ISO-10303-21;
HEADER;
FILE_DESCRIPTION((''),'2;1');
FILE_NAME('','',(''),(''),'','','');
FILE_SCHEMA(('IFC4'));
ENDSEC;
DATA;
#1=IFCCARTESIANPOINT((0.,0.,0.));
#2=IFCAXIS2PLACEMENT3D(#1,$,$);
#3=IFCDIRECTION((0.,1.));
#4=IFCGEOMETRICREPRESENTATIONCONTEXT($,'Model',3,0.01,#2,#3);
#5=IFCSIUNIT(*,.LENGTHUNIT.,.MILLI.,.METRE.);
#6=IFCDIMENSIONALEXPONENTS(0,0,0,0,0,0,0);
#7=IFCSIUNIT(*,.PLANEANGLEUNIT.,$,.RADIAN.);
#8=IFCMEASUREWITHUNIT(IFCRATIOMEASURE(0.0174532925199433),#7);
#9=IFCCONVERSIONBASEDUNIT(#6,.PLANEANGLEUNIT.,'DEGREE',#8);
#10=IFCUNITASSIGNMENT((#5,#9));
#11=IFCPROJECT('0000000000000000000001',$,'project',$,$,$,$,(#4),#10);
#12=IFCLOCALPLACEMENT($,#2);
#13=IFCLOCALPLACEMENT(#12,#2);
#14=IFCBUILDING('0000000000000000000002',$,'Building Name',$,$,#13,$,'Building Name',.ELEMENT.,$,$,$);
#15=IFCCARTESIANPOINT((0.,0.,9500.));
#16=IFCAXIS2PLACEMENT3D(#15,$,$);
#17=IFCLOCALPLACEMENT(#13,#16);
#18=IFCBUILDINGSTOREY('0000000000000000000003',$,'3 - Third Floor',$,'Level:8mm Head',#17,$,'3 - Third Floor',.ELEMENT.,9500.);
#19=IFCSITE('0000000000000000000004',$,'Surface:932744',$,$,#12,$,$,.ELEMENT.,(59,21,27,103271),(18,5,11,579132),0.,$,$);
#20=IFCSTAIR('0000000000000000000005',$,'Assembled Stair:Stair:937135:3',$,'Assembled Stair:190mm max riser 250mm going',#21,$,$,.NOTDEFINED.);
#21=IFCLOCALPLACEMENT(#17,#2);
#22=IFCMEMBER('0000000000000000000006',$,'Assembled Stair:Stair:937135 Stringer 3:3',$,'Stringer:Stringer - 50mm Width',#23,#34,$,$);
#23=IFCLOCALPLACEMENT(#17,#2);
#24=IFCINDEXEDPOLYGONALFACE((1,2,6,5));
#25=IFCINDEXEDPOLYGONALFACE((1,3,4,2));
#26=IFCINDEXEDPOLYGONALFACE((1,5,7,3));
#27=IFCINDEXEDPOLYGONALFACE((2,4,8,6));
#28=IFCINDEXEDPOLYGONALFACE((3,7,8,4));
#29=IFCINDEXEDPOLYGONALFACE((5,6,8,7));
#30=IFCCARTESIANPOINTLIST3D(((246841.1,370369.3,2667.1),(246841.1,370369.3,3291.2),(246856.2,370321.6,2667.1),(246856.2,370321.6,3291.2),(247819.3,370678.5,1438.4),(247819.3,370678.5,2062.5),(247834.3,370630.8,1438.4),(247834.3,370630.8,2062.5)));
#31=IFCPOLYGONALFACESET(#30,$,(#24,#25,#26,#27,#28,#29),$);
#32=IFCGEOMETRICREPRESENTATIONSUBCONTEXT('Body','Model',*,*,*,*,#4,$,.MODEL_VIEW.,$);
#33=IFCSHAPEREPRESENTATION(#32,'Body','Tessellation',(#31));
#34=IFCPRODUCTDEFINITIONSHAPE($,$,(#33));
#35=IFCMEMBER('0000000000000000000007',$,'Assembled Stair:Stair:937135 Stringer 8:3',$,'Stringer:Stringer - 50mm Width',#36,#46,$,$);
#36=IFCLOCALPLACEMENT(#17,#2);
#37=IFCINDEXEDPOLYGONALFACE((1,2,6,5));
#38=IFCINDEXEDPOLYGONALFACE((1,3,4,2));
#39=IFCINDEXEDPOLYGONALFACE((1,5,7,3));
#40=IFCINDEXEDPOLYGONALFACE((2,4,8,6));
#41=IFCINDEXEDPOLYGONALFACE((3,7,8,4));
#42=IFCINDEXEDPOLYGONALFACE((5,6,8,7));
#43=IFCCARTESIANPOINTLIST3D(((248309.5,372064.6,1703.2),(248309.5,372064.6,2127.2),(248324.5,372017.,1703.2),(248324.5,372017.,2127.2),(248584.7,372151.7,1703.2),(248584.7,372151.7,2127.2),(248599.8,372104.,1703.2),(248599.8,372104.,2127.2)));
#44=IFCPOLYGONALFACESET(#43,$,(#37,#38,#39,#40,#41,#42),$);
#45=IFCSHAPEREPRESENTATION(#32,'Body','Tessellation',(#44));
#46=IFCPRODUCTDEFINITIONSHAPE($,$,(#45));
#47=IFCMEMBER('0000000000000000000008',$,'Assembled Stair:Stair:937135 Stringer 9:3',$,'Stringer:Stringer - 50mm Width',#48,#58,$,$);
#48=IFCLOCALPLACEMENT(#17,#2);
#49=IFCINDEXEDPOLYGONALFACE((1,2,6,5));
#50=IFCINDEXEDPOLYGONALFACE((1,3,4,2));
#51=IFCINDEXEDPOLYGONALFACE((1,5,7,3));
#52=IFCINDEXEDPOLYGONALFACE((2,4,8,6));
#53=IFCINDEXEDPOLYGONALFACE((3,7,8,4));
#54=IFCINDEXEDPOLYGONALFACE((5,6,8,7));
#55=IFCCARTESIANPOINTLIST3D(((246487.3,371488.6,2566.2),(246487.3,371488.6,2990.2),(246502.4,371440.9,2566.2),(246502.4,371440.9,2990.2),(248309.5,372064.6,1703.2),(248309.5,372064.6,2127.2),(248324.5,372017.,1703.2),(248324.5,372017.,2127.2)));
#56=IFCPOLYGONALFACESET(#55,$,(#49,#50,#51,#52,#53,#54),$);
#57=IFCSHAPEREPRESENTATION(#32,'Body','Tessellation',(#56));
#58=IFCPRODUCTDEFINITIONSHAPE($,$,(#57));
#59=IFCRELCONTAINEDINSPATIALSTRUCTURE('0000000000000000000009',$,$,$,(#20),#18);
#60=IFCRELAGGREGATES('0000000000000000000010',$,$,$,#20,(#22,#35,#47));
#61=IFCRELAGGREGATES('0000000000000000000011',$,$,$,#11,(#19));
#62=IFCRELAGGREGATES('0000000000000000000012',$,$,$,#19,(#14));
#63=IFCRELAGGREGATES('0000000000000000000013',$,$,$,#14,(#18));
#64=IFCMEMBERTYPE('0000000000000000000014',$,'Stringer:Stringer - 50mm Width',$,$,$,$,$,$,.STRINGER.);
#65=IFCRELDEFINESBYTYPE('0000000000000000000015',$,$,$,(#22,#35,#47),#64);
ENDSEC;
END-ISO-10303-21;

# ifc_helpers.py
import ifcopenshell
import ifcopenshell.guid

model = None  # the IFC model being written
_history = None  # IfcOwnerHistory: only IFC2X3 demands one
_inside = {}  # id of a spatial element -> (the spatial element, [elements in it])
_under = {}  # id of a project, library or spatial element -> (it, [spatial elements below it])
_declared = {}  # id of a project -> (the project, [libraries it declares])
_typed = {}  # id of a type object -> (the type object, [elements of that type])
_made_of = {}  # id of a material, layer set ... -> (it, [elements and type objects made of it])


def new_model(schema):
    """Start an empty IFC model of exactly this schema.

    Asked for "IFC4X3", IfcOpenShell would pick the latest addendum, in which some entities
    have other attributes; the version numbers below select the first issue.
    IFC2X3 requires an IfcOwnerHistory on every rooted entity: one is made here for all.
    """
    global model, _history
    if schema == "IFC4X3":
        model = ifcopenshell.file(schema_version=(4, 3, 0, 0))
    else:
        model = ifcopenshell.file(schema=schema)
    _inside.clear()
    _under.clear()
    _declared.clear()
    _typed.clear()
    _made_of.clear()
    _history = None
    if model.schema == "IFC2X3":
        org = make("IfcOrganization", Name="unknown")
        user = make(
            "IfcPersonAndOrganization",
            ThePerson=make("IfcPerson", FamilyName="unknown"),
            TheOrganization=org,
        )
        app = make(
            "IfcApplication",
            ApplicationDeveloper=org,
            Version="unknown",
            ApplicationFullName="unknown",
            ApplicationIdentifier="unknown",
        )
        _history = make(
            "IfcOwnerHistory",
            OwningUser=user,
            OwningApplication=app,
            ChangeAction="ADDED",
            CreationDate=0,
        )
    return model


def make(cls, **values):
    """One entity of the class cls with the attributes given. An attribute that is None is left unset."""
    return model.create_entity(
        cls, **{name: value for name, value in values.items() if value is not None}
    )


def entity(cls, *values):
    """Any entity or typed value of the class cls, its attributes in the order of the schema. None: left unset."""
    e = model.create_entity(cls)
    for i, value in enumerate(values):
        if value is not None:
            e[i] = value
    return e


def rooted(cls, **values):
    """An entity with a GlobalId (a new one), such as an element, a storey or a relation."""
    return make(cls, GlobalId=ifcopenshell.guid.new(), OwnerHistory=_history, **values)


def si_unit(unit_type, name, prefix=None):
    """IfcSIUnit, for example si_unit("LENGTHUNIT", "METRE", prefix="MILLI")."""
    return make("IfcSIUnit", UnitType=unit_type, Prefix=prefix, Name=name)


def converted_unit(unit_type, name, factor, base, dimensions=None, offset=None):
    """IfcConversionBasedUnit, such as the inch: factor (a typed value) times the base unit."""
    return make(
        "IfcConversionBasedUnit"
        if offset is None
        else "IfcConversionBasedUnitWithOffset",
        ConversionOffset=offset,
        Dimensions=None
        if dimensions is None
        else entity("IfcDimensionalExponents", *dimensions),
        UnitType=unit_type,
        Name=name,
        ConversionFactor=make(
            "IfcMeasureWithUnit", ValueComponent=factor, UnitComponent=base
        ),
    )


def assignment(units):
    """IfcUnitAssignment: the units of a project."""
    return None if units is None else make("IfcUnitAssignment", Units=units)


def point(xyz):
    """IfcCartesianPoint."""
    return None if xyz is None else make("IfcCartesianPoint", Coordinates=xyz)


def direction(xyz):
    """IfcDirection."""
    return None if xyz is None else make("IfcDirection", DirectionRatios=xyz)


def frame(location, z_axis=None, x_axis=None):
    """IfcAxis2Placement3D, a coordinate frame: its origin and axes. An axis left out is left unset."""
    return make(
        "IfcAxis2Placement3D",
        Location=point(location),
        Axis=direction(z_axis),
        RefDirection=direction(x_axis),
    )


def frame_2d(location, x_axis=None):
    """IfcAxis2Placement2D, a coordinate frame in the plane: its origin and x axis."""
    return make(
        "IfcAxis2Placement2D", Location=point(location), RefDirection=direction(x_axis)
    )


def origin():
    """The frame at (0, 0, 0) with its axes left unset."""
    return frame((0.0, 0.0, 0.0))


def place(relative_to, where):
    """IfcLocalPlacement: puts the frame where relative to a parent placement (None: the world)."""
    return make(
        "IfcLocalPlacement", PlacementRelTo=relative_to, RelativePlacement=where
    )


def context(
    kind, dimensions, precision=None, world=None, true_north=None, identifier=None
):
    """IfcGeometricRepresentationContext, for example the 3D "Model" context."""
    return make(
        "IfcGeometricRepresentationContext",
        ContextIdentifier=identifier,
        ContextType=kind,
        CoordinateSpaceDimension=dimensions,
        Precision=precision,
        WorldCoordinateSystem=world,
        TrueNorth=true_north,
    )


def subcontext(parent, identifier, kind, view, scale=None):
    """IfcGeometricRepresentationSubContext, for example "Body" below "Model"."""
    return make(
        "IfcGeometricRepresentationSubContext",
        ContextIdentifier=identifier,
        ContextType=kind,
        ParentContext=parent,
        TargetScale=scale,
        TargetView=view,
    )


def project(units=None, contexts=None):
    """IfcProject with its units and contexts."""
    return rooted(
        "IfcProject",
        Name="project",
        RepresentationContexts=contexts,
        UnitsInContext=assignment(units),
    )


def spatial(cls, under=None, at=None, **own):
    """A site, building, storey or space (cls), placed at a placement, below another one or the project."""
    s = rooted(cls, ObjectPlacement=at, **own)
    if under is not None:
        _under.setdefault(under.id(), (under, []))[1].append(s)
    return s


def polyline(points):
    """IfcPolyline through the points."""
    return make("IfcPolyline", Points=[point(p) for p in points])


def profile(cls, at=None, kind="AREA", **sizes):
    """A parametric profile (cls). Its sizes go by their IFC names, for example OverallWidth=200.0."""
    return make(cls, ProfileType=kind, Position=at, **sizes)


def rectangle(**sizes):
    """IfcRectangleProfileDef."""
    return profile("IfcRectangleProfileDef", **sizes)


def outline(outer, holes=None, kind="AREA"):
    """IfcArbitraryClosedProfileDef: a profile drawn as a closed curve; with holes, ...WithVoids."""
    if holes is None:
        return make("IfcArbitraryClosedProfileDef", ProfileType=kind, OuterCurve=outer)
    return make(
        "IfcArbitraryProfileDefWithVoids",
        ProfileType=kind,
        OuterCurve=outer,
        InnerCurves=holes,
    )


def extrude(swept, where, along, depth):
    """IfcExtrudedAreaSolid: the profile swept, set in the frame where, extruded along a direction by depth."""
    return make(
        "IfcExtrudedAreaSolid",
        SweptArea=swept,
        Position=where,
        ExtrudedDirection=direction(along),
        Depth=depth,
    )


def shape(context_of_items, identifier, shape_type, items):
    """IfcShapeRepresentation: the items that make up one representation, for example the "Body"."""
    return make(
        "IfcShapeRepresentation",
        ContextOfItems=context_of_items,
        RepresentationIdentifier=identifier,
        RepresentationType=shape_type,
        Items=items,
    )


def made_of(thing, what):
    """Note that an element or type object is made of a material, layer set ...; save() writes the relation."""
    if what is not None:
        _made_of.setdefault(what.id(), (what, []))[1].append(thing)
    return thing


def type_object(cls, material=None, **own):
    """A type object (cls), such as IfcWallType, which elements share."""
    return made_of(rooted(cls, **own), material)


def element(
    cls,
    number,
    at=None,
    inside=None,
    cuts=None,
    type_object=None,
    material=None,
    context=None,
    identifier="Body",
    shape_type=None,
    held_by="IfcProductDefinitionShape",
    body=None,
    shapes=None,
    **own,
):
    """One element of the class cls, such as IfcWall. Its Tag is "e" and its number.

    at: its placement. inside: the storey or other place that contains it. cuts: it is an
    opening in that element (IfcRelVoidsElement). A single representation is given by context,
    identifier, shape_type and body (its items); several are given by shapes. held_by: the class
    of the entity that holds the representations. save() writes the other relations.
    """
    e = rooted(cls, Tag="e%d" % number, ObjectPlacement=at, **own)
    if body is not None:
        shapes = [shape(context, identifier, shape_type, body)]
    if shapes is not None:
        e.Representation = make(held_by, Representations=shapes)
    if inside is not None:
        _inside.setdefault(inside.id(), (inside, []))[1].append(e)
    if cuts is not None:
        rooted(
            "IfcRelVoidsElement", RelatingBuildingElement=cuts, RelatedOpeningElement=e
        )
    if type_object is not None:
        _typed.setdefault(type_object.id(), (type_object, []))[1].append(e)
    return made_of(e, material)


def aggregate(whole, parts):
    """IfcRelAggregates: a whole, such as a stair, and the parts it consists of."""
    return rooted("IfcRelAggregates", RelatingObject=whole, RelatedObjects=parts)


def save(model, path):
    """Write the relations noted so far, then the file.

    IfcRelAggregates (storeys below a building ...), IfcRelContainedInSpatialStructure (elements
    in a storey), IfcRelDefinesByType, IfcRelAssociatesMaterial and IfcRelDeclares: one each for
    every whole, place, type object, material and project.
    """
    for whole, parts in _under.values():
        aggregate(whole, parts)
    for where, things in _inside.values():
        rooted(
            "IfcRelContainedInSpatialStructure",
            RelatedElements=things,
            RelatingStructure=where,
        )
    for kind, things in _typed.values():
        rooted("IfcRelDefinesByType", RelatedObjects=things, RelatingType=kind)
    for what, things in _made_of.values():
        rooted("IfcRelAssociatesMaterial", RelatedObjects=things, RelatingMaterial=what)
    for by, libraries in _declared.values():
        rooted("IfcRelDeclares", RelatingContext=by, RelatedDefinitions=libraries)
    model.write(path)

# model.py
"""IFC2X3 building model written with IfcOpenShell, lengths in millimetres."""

from ifc_helpers import new_model, entity, si_unit, converted_unit, direction, frame, frame_2d, origin, place, context, subcontext, project, spatial, polyline, rectangle, outline, extrude, type_object, element, aggregate, save


model = new_model("IFC2X3")

# Units and contexts
model_context = context("Model", 3, precision=0.01, world=origin(), true_north=direction((0.0, 1.0)))
body_context = subcontext(model_context, "Body", "Model", "MODEL_VIEW")
ifc_project = project(units=[si_unit("LENGTHUNIT", "METRE", prefix="MILLI"), converted_unit("PLANEANGLEUNIT", "DEGREE", entity("IfcRatioMeasure", 0.0174532925199433), si_unit("PLANEANGLEUNIT", "RADIAN"), dimensions=[0, 0, 0, 0, 0, 0, 0])], contexts=[model_context])

# Site, building, storey
site_placement = place(None, origin())
site = spatial("IfcSite", under=ifc_project, at=site_placement, Name="Surface:932744", CompositionType="ELEMENT", RefLatitude=(59, 21, 27, 103271), RefLongitude=(18, 5, 11, 579132), RefElevation=0.0)
building_placement = place(site_placement, origin())
building = spatial("IfcBuilding", under=site, at=building_placement, Name="Building Name", LongName="Building Name", CompositionType="ELEMENT")
storey_placement = place(building_placement, frame((0.0, 0.0, 9500.0)))
storey = spatial("IfcBuildingStorey", under=building, at=storey_placement, Name="3 - Third Floor", ObjectType="Level:8mm Head", LongName="3 - Third Floor", CompositionType="ELEMENT", Elevation=9500.0)

# Stair, members
stair_placement = place(storey_placement, origin())
stair = element("IfcStair", 1, at=stair_placement, inside=storey, Name="Assembled Stair:Stair:937135:3", ObjectType="Assembled Stair:190mm max riser 250mm going", ShapeType="NOTDEFINED")
member_type = type_object("IfcMemberType", Name="Stringer:Stringer - 50mm Width", PredefinedType="STRINGER")
member_1_placement = place(stair_placement, origin())
member_1 = element("IfcMember", 2, at=member_1_placement, type_object=member_type, Name="Assembled Stair:Stair:937135 Stringer 3:3", ObjectType="Stringer:Stringer - 50mm Width", context=body_context, shape_type="SweptSolid", body=[
    extrude(outline(polyline([(-1039.9, -200.0), (560.8, -200.0), (1039.9, 200.0), (-560.8, 200.0), (-1039.9, -200.0)])), frame((247345.3, 370476.2, 2364.8), z_axis=(-0.301424, 0.95349, 0.0), x_axis=(-0.611082, -0.193179, 0.767633)), (0.0, 0.0, 1.0), 50.0),
])
member_2_placement = place(stair_placement, origin())
member_2 = element("IfcMember", 3, at=member_2_placement, type_object=member_type, Name="Assembled Stair:Stair:937135 Stringer 8:3", ObjectType="Stringer:Stringer - 50mm Width", context=body_context, shape_type="SweptSolid", body=[
    extrude(rectangle(XDim=288.7, YDim=50.0, at=frame_2d((0.0, 0.0), x_axis=(1.0, 0.0))), frame((248454.6, 372084.3, 1703.2), z_axis=(0.0, 0.0, 1.0), x_axis=(-0.95349, -0.301424, 0.0)), (0.0, 0.0, 1.0), 424.0),
])
member_3_placement = place(stair_placement, origin())
member_3 = element("IfcMember", 4, at=member_3_placement, type_object=member_type, Name="Assembled Stair:Stair:937135 Stringer 9:3", ObjectType="Stringer:Stringer - 50mm Width", context=body_context, shape_type="SweptSolid", body=[
    extrude(outline(polyline([(-1135.7, -193.2), (961.2, -193.2), (1135.7, 193.2), (-961.2, 193.2), (-1135.7, -193.2)])), frame((247413.5, 371728.9, 2346.7), z_axis=(-0.301424, 0.95349, 0.0), x_axis=(-0.868997, -0.274713, 0.411555)), (0.0, 0.0, 1.0), 50.0),
])

aggregate(stair, [member_1, member_2, member_3])

save(model, "model.ifc")
